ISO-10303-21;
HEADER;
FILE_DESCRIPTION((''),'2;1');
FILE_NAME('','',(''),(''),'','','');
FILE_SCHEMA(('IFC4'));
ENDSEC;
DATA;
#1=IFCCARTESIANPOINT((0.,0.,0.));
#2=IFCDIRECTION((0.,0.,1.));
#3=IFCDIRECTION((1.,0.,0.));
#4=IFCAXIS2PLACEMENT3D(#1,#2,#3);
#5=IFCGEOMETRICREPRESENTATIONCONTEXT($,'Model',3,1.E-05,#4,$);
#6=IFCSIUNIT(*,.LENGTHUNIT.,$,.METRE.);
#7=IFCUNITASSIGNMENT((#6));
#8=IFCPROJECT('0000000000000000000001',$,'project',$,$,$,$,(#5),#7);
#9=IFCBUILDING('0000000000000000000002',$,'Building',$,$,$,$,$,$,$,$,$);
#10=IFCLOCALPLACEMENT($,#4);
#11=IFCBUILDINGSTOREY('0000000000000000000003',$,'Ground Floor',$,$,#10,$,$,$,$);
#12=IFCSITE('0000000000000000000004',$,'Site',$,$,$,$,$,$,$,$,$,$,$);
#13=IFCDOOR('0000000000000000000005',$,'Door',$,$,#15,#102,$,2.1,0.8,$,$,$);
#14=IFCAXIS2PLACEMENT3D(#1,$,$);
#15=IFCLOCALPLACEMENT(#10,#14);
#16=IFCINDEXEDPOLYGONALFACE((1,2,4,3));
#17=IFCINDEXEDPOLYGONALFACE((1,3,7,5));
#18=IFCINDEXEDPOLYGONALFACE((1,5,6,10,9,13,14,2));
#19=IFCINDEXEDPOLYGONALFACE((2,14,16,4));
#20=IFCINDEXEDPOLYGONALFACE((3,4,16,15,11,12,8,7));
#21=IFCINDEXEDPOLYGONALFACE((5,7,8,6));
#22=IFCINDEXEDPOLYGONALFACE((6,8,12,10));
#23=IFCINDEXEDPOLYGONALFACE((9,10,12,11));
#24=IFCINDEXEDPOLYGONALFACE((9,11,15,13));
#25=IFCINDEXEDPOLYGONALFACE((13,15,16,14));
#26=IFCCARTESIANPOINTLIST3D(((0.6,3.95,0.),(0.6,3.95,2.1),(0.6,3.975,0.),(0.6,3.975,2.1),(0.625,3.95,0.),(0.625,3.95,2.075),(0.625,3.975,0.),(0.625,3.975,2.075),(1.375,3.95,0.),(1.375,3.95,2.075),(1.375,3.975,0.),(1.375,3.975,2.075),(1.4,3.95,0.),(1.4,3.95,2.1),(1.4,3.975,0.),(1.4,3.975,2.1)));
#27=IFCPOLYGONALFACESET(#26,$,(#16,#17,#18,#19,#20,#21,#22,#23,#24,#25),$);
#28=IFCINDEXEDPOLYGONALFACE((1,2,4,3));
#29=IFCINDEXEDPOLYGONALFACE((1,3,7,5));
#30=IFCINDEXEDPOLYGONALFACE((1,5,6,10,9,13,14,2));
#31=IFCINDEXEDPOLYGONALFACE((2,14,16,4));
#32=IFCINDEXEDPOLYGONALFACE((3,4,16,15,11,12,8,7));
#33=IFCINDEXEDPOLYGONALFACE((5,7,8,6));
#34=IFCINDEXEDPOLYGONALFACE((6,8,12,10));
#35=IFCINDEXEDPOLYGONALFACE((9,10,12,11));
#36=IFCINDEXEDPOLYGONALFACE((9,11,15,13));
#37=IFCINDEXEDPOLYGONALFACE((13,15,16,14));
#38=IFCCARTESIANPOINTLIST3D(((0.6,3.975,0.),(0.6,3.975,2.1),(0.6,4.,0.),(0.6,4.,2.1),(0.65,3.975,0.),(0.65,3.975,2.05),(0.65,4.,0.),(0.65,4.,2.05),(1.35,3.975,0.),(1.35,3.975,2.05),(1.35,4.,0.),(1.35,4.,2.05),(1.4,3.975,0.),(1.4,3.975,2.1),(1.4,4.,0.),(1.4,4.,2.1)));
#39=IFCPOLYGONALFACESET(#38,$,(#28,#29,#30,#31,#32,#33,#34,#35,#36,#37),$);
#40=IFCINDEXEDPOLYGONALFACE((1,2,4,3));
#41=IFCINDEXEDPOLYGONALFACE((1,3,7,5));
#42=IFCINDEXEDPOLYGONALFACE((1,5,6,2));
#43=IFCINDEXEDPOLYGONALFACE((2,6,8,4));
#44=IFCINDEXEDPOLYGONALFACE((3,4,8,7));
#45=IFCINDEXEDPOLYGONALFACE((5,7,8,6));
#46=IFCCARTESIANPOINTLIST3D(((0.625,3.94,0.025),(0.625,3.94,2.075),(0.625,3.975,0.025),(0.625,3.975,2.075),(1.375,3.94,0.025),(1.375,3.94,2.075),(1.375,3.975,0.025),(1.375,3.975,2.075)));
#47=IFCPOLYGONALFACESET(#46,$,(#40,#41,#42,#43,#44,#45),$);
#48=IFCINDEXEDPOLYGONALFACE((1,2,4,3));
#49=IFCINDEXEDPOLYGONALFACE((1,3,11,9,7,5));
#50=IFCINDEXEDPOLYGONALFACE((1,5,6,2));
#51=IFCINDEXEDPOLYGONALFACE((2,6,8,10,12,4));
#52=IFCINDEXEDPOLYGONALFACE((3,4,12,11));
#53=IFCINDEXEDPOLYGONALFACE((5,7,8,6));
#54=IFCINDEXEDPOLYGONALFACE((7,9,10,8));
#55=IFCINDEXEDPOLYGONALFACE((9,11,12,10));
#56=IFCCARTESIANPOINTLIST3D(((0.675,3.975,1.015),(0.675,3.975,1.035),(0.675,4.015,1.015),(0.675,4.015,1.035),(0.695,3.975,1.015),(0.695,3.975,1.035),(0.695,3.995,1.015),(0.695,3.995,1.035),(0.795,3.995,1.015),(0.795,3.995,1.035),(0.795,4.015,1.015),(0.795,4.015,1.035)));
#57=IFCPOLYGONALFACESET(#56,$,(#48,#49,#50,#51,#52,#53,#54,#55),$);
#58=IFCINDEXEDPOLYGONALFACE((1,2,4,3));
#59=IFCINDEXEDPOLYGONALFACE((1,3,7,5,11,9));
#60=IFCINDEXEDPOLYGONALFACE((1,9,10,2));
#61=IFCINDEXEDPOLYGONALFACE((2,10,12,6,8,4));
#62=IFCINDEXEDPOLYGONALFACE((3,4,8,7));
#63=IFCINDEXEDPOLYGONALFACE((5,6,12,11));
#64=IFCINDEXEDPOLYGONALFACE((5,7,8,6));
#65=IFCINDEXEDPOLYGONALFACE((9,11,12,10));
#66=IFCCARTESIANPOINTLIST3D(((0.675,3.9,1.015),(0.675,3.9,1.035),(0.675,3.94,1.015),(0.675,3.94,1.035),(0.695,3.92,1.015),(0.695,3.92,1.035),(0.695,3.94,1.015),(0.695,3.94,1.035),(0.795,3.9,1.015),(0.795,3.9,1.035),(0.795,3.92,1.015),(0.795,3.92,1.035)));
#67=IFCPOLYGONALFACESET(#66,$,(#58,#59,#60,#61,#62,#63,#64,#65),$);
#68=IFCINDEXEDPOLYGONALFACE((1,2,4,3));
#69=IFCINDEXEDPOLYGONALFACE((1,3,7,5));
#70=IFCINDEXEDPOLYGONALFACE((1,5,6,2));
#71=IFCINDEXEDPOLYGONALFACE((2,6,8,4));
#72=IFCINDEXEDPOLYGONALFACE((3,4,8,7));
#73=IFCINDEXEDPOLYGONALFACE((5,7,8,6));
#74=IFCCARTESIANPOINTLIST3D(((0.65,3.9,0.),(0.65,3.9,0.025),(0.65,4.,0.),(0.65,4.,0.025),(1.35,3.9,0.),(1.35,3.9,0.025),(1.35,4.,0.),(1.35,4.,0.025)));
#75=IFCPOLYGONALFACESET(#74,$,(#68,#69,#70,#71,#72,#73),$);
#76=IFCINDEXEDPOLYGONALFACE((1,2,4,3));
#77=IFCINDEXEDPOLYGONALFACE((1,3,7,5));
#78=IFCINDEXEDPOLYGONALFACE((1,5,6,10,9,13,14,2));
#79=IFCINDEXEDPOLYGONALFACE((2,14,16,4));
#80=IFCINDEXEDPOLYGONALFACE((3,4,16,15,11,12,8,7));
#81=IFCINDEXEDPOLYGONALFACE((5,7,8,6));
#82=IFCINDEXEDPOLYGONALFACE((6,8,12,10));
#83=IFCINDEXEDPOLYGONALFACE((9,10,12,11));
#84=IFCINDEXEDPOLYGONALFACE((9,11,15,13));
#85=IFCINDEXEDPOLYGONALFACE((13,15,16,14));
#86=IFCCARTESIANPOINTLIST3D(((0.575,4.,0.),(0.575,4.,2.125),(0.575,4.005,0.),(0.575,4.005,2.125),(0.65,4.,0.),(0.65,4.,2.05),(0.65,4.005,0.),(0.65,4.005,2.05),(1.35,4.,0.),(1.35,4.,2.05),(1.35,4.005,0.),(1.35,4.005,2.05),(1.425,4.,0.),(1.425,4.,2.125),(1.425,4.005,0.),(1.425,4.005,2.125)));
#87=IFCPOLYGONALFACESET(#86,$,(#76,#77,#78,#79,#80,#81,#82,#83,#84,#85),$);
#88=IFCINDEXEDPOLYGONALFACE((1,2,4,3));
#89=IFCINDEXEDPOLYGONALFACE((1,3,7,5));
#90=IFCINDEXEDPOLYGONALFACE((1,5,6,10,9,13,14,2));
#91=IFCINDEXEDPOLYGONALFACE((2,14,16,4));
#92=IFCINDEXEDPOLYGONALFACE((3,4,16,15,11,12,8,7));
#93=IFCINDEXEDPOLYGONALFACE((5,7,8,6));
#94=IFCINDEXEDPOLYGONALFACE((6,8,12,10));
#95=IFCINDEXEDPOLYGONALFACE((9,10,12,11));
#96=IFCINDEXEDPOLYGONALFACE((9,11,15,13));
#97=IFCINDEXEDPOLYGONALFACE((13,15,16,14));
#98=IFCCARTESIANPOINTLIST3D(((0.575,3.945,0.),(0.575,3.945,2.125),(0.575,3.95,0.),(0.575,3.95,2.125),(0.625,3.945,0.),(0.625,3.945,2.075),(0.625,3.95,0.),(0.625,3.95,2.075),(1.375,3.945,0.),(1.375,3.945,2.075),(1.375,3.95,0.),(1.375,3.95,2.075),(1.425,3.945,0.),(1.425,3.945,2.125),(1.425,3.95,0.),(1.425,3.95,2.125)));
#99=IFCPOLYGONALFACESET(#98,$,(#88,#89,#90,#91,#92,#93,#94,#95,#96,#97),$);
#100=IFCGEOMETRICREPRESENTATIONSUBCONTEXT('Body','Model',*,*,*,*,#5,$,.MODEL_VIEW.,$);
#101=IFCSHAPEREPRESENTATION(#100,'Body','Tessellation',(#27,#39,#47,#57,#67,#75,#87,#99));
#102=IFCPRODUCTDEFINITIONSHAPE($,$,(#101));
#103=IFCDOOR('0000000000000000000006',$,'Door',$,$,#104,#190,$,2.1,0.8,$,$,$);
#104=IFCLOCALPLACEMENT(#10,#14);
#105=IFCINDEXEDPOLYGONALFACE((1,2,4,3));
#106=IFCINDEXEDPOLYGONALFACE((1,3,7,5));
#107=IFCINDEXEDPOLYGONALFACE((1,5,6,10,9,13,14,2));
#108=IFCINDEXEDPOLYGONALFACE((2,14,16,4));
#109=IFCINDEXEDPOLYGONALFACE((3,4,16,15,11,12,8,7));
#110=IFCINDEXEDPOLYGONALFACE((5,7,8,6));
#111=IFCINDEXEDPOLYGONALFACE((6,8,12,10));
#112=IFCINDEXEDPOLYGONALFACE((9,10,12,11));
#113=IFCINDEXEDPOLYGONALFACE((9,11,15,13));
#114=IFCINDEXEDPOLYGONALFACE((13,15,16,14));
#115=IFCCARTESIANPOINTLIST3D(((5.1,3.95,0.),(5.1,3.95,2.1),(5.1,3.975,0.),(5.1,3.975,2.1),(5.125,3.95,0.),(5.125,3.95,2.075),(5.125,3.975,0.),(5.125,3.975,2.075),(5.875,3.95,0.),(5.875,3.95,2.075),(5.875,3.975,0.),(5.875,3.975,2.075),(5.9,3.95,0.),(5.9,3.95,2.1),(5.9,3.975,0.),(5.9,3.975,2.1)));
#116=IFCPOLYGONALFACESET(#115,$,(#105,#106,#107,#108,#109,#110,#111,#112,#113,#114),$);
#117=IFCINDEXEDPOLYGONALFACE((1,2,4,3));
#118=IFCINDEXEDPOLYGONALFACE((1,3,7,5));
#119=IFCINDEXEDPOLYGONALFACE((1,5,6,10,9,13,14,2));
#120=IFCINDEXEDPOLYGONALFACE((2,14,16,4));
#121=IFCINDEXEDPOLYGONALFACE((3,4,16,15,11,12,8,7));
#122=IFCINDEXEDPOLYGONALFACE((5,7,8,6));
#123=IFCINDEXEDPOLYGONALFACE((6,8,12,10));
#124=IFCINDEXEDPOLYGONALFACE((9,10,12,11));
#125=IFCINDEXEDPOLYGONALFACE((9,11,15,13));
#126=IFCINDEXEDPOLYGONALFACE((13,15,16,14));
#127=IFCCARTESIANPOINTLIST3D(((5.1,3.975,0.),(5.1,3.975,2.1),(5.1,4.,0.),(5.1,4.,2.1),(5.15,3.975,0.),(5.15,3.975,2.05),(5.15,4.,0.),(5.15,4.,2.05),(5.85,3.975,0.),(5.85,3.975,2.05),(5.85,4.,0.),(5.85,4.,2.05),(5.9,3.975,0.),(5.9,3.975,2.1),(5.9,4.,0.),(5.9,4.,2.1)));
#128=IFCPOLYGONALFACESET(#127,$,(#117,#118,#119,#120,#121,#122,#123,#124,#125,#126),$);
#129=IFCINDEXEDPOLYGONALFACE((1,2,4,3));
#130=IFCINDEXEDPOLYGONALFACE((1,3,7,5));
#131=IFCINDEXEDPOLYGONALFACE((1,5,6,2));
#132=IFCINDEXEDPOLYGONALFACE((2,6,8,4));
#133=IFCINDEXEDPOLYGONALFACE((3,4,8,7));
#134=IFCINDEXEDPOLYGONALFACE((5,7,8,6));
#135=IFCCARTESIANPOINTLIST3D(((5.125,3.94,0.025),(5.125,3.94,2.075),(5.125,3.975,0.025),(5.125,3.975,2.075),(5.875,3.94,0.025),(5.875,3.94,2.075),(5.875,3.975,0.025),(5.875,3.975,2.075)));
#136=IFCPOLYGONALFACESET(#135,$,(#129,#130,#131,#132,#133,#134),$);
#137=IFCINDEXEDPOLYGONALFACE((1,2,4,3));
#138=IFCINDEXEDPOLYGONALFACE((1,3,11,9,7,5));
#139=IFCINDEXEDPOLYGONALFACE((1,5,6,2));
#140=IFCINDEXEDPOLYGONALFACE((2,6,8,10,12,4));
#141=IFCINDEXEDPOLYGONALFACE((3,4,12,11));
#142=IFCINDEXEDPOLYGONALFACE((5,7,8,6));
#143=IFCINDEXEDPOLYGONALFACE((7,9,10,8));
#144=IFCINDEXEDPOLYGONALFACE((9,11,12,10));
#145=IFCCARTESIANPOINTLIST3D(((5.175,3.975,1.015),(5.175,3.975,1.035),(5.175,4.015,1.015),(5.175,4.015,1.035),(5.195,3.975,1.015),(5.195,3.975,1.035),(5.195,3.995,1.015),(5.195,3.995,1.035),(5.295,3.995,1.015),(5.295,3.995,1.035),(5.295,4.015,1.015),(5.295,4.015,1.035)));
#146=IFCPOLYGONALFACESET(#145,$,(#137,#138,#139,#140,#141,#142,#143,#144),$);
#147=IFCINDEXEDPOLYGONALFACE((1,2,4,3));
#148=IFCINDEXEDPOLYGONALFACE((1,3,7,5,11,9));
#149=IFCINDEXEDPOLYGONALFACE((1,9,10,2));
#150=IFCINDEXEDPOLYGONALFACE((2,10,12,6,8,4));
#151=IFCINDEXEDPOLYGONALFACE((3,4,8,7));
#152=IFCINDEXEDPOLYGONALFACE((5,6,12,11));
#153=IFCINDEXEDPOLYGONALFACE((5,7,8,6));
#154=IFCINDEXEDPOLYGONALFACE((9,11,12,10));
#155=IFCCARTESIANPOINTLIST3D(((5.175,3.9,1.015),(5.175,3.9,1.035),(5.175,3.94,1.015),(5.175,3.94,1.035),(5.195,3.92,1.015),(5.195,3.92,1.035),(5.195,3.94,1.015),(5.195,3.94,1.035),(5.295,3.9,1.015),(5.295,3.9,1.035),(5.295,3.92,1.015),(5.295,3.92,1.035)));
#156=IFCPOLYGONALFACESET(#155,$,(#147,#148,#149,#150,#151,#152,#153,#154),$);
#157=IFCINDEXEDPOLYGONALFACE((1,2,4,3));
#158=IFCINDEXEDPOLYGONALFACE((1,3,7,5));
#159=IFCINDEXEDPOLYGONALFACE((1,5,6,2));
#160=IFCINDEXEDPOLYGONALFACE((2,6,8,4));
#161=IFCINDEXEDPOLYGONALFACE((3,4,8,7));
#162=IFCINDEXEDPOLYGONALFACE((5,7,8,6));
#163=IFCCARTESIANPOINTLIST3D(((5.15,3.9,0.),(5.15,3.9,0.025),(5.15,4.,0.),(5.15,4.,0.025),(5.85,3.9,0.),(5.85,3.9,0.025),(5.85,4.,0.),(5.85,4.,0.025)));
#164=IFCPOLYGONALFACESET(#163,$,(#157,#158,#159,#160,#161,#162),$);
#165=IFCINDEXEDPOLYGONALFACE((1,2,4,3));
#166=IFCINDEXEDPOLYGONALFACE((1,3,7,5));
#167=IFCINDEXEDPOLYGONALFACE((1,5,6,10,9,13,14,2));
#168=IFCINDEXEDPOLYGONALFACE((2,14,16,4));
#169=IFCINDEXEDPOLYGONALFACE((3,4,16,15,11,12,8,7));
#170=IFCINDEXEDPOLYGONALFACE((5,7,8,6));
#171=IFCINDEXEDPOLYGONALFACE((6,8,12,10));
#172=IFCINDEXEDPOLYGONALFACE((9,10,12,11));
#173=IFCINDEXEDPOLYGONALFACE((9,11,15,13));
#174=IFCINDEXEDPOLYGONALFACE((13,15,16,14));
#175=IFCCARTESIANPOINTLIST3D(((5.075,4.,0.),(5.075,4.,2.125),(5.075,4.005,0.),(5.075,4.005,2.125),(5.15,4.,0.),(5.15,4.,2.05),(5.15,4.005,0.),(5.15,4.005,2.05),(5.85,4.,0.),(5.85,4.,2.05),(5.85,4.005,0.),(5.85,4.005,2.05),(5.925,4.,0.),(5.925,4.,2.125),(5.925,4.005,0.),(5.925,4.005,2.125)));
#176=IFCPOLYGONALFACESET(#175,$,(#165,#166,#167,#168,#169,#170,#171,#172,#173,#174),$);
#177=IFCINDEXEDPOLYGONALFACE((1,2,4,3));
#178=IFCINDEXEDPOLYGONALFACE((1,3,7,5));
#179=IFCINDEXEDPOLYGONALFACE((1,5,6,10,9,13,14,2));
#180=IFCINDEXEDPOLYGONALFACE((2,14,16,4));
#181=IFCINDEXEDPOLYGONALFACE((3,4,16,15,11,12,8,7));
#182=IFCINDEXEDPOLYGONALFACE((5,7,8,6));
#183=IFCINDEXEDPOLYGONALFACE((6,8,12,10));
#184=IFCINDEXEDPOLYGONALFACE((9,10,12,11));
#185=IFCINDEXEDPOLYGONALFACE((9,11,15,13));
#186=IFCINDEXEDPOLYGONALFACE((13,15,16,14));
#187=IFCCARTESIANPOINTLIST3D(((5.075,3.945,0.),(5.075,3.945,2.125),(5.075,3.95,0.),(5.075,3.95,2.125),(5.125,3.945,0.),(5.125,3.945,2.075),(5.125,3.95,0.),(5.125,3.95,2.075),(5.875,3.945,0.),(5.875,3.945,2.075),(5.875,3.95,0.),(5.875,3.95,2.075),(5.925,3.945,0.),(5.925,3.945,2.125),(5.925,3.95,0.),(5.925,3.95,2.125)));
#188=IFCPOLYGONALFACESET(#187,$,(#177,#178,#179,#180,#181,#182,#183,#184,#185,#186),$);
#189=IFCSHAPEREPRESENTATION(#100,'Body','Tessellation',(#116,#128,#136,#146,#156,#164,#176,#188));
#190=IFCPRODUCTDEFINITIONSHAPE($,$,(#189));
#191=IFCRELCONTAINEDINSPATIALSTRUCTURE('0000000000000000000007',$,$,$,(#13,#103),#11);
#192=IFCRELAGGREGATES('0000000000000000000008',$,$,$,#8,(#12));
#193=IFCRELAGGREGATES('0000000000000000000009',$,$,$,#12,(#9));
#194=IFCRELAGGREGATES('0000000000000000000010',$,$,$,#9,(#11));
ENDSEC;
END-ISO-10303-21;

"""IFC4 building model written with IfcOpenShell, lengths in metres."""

from ifc_helpers import new_model, si_unit, frame, origin_with_axes, place, context, subcontext, project, spatial, line, indexed_curve, outline, extrude, element, save


model = new_model("IFC4")

# Units and contexts
model_context = context("Model", 3, precision=1e-05, world=origin_with_axes())
body_context = subcontext(model_context, "Body", "Model", "MODEL_VIEW")
ifc_project = project(units=[si_unit("LENGTHUNIT", "METRE")], contexts=[model_context])

# Site, building, storey
site = spatial("IfcSite", under=ifc_project, Name="Site")
building = spatial("IfcBuilding", under=site, Name="Building")
storey_placement = place(None, origin_with_axes())
storey = spatial("IfcBuildingStorey", under=building, at=storey_placement, Name="Ground Floor")

# Doors
door_1_placement = place(storey_placement, frame((1.4, 4.0, 0.0), z_axis=(0.0, 0.0, 1.0), x_axis=(-1.0, 0.0, 0.0)))
element("IfcDoor", 1, at=door_1_placement, inside=storey, Name="Door", OverallHeight=2.1, OverallWidth=0.8, context=body_context, shape_type="SweptSolid", body=[
    extrude(outline(indexed_curve([(0.0, 0.0), (0.0, 2.1), (0.8, 2.1), (0.8, 0.0), (0.775, 0.0), (0.775, 2.075), (0.025, 2.075), (0.025, 0.0)], segments=[line(1, 2, 3, 4, 5, 6, 7, 8, 1)])), frame((0.0, 0.025, 0.0), z_axis=(0.0, -1.0, 0.0), x_axis=(1.0, 0.0, 0.0)), (0.0, 0.0, -1.0), 0.025),
    extrude(outline(indexed_curve([(0.0, 0.0), (0.0, 2.1), (0.8, 2.1), (0.8, 0.0), (0.75, 0.0), (0.75, 2.05), (0.05, 2.05), (0.05, 0.0)], segments=[line(1, 2, 3, 4, 5, 6, 7, 8, 1)])), frame((0.0, 0.0, 0.0), z_axis=(0.0, -1.0, 0.0), x_axis=(1.0, 0.0, 0.0)), (0.0, 0.0, -1.0), 0.025),
    extrude(outline(indexed_curve([(0.0, 0.0), (0.75, 0.0), (0.75, 0.035), (0.0, 0.035)], segments=[line(1, 2, 3, 4, 1)])), frame((0.025, 0.025, 0.025), z_axis=(0.0, 0.0, 1.0), x_axis=(1.0, 0.0, 0.0)), (0.0, 0.0, 1.0), 2.05),
    extrude(outline(indexed_curve([(0.0, 0.0), (0.0, -0.04), (-0.12, -0.04), (-0.12, -0.02), (-0.02, -0.02), (-0.02, 0.0)], segments=[line(1, 2, 3, 4, 5, 6, 1)])), frame((0.725, 0.025, 1.015), z_axis=(0.0, 0.0, 1.0), x_axis=(1.0, 0.0, 0.0)), (0.0, 0.0, 1.0), 0.02),
    extrude(outline(indexed_curve([(0.0, 0.0), (0.0, 0.04), (-0.12, 0.04), (-0.12, 0.02), (-0.02, 0.02), (-0.02, 0.0)], segments=[line(1, 2, 3, 4, 5, 6, 1)])), frame((0.725, 0.06, 1.015), z_axis=(0.0, 0.0, 1.0), x_axis=(1.0, 0.0, 0.0)), (0.0, 0.0, 1.0), 0.02),
    extrude(outline(indexed_curve([(0.0, 0.0), (0.7, 0.0), (0.7, 0.1), (0.0, 0.1)], segments=[line(1, 2, 3, 4, 1)])), frame((0.05, 0.0, 0.0), z_axis=(0.0, 0.0, 1.0), x_axis=(1.0, 0.0, 0.0)), (0.0, 0.0, 1.0), 0.025),
    extrude(outline(indexed_curve([(0.0, 0.0), (0.0, 2.125), (0.85, 2.125), (0.85, 0.0), (0.775, 0.0), (0.775, 2.05), (0.075, 2.05), (0.075, 0.0)], segments=[line(1, 2, 3, 4, 5, 6, 7, 8, 1)])), frame((-0.025, -0.005, 0.0), z_axis=(0.0, -1.0, 0.0), x_axis=(1.0, 0.0, 0.0)), (0.0, 0.0, -1.0), 0.005),
    extrude(outline(indexed_curve([(0.0, 0.0), (0.0, 2.125), (0.85, 2.125), (0.85, 0.0), (0.8, 0.0), (0.8, 2.075), (0.05, 2.075), (0.05, 0.0)], segments=[line(1, 2, 3, 4, 5, 6, 7, 8, 1)])), frame((-0.025, 0.05, 0.0), z_axis=(0.0, -1.0, 0.0), x_axis=(1.0, 0.0, 0.0)), (0.0, 0.0, -1.0), 0.005),
])
door_2_placement = place(storey_placement, frame((5.9, 4.0, 0.0), z_axis=(0.0, 0.0, 1.0), x_axis=(-1.0, 0.0, 0.0)))
element("IfcDoor", 2, at=door_2_placement, inside=storey, Name="Door", OverallHeight=2.1, OverallWidth=0.8, context=body_context, shape_type="SweptSolid", body=[
    extrude(outline(indexed_curve([(0.0, 0.0), (0.0, 2.1), (0.8, 2.1), (0.8, 0.0), (0.775, 0.0), (0.775, 2.075), (0.025, 2.075), (0.025, 0.0)], segments=[line(1, 2, 3, 4, 5, 6, 7, 8, 1)])), frame((0.0, 0.025, 0.0), z_axis=(0.0, -1.0, 0.0), x_axis=(1.0, 0.0, 0.0)), (0.0, 0.0, -1.0), 0.025),
    extrude(outline(indexed_curve([(0.0, 0.0), (0.0, 2.1), (0.8, 2.1), (0.8, 0.0), (0.75, 0.0), (0.75, 2.05), (0.05, 2.05), (0.05, 0.0)], segments=[line(1, 2, 3, 4, 5, 6, 7, 8, 1)])), frame((0.0, 0.0, 0.0), z_axis=(0.0, -1.0, 0.0), x_axis=(1.0, 0.0, 0.0)), (0.0, 0.0, -1.0), 0.025),
    extrude(outline(indexed_curve([(0.0, 0.0), (0.75, 0.0), (0.75, 0.035), (0.0, 0.035)], segments=[line(1, 2, 3, 4, 1)])), frame((0.025, 0.025, 0.025), z_axis=(0.0, 0.0, 1.0), x_axis=(1.0, 0.0, 0.0)), (0.0, 0.0, 1.0), 2.05),
    extrude(outline(indexed_curve([(0.0, 0.0), (0.0, -0.04), (-0.12, -0.04), (-0.12, -0.02), (-0.02, -0.02), (-0.02, 0.0)], segments=[line(1, 2, 3, 4, 5, 6, 1)])), frame((0.725, 0.025, 1.015), z_axis=(0.0, 0.0, 1.0), x_axis=(1.0, 0.0, 0.0)), (0.0, 0.0, 1.0), 0.02),
    extrude(outline(indexed_curve([(0.0, 0.0), (0.0, 0.04), (-0.12, 0.04), (-0.12, 0.02), (-0.02, 0.02), (-0.02, 0.0)], segments=[line(1, 2, 3, 4, 5, 6, 1)])), frame((0.725, 0.06, 1.015), z_axis=(0.0, 0.0, 1.0), x_axis=(1.0, 0.0, 0.0)), (0.0, 0.0, 1.0), 0.02),
    extrude(outline(indexed_curve([(0.0, 0.0), (0.7, 0.0), (0.7, 0.1), (0.0, 0.1)], segments=[line(1, 2, 3, 4, 1)])), frame((0.05, 0.0, 0.0), z_axis=(0.0, 0.0, 1.0), x_axis=(1.0, 0.0, 0.0)), (0.0, 0.0, 1.0), 0.025),
    extrude(outline(indexed_curve([(0.0, 0.0), (0.0, 2.125), (0.85, 2.125), (0.85, 0.0), (0.775, 0.0), (0.775, 2.05), (0.075, 2.05), (0.075, 0.0)], segments=[line(1, 2, 3, 4, 5, 6, 7, 8, 1)])), frame((-0.025, -0.005, 0.0), z_axis=(0.0, -1.0, 0.0), x_axis=(1.0, 0.0, 0.0)), (0.0, 0.0, -1.0), 0.005),
    extrude(outline(indexed_curve([(0.0, 0.0), (0.0, 2.125), (0.85, 2.125), (0.85, 0.0), (0.8, 0.0), (0.8, 2.075), (0.05, 2.075), (0.05, 0.0)], segments=[line(1, 2, 3, 4, 5, 6, 7, 8, 1)])), frame((-0.025, 0.05, 0.0), z_axis=(0.0, -1.0, 0.0), x_axis=(1.0, 0.0, 0.0)), (0.0, 0.0, -1.0), 0.005),
])

save(model, "model.ifc")
